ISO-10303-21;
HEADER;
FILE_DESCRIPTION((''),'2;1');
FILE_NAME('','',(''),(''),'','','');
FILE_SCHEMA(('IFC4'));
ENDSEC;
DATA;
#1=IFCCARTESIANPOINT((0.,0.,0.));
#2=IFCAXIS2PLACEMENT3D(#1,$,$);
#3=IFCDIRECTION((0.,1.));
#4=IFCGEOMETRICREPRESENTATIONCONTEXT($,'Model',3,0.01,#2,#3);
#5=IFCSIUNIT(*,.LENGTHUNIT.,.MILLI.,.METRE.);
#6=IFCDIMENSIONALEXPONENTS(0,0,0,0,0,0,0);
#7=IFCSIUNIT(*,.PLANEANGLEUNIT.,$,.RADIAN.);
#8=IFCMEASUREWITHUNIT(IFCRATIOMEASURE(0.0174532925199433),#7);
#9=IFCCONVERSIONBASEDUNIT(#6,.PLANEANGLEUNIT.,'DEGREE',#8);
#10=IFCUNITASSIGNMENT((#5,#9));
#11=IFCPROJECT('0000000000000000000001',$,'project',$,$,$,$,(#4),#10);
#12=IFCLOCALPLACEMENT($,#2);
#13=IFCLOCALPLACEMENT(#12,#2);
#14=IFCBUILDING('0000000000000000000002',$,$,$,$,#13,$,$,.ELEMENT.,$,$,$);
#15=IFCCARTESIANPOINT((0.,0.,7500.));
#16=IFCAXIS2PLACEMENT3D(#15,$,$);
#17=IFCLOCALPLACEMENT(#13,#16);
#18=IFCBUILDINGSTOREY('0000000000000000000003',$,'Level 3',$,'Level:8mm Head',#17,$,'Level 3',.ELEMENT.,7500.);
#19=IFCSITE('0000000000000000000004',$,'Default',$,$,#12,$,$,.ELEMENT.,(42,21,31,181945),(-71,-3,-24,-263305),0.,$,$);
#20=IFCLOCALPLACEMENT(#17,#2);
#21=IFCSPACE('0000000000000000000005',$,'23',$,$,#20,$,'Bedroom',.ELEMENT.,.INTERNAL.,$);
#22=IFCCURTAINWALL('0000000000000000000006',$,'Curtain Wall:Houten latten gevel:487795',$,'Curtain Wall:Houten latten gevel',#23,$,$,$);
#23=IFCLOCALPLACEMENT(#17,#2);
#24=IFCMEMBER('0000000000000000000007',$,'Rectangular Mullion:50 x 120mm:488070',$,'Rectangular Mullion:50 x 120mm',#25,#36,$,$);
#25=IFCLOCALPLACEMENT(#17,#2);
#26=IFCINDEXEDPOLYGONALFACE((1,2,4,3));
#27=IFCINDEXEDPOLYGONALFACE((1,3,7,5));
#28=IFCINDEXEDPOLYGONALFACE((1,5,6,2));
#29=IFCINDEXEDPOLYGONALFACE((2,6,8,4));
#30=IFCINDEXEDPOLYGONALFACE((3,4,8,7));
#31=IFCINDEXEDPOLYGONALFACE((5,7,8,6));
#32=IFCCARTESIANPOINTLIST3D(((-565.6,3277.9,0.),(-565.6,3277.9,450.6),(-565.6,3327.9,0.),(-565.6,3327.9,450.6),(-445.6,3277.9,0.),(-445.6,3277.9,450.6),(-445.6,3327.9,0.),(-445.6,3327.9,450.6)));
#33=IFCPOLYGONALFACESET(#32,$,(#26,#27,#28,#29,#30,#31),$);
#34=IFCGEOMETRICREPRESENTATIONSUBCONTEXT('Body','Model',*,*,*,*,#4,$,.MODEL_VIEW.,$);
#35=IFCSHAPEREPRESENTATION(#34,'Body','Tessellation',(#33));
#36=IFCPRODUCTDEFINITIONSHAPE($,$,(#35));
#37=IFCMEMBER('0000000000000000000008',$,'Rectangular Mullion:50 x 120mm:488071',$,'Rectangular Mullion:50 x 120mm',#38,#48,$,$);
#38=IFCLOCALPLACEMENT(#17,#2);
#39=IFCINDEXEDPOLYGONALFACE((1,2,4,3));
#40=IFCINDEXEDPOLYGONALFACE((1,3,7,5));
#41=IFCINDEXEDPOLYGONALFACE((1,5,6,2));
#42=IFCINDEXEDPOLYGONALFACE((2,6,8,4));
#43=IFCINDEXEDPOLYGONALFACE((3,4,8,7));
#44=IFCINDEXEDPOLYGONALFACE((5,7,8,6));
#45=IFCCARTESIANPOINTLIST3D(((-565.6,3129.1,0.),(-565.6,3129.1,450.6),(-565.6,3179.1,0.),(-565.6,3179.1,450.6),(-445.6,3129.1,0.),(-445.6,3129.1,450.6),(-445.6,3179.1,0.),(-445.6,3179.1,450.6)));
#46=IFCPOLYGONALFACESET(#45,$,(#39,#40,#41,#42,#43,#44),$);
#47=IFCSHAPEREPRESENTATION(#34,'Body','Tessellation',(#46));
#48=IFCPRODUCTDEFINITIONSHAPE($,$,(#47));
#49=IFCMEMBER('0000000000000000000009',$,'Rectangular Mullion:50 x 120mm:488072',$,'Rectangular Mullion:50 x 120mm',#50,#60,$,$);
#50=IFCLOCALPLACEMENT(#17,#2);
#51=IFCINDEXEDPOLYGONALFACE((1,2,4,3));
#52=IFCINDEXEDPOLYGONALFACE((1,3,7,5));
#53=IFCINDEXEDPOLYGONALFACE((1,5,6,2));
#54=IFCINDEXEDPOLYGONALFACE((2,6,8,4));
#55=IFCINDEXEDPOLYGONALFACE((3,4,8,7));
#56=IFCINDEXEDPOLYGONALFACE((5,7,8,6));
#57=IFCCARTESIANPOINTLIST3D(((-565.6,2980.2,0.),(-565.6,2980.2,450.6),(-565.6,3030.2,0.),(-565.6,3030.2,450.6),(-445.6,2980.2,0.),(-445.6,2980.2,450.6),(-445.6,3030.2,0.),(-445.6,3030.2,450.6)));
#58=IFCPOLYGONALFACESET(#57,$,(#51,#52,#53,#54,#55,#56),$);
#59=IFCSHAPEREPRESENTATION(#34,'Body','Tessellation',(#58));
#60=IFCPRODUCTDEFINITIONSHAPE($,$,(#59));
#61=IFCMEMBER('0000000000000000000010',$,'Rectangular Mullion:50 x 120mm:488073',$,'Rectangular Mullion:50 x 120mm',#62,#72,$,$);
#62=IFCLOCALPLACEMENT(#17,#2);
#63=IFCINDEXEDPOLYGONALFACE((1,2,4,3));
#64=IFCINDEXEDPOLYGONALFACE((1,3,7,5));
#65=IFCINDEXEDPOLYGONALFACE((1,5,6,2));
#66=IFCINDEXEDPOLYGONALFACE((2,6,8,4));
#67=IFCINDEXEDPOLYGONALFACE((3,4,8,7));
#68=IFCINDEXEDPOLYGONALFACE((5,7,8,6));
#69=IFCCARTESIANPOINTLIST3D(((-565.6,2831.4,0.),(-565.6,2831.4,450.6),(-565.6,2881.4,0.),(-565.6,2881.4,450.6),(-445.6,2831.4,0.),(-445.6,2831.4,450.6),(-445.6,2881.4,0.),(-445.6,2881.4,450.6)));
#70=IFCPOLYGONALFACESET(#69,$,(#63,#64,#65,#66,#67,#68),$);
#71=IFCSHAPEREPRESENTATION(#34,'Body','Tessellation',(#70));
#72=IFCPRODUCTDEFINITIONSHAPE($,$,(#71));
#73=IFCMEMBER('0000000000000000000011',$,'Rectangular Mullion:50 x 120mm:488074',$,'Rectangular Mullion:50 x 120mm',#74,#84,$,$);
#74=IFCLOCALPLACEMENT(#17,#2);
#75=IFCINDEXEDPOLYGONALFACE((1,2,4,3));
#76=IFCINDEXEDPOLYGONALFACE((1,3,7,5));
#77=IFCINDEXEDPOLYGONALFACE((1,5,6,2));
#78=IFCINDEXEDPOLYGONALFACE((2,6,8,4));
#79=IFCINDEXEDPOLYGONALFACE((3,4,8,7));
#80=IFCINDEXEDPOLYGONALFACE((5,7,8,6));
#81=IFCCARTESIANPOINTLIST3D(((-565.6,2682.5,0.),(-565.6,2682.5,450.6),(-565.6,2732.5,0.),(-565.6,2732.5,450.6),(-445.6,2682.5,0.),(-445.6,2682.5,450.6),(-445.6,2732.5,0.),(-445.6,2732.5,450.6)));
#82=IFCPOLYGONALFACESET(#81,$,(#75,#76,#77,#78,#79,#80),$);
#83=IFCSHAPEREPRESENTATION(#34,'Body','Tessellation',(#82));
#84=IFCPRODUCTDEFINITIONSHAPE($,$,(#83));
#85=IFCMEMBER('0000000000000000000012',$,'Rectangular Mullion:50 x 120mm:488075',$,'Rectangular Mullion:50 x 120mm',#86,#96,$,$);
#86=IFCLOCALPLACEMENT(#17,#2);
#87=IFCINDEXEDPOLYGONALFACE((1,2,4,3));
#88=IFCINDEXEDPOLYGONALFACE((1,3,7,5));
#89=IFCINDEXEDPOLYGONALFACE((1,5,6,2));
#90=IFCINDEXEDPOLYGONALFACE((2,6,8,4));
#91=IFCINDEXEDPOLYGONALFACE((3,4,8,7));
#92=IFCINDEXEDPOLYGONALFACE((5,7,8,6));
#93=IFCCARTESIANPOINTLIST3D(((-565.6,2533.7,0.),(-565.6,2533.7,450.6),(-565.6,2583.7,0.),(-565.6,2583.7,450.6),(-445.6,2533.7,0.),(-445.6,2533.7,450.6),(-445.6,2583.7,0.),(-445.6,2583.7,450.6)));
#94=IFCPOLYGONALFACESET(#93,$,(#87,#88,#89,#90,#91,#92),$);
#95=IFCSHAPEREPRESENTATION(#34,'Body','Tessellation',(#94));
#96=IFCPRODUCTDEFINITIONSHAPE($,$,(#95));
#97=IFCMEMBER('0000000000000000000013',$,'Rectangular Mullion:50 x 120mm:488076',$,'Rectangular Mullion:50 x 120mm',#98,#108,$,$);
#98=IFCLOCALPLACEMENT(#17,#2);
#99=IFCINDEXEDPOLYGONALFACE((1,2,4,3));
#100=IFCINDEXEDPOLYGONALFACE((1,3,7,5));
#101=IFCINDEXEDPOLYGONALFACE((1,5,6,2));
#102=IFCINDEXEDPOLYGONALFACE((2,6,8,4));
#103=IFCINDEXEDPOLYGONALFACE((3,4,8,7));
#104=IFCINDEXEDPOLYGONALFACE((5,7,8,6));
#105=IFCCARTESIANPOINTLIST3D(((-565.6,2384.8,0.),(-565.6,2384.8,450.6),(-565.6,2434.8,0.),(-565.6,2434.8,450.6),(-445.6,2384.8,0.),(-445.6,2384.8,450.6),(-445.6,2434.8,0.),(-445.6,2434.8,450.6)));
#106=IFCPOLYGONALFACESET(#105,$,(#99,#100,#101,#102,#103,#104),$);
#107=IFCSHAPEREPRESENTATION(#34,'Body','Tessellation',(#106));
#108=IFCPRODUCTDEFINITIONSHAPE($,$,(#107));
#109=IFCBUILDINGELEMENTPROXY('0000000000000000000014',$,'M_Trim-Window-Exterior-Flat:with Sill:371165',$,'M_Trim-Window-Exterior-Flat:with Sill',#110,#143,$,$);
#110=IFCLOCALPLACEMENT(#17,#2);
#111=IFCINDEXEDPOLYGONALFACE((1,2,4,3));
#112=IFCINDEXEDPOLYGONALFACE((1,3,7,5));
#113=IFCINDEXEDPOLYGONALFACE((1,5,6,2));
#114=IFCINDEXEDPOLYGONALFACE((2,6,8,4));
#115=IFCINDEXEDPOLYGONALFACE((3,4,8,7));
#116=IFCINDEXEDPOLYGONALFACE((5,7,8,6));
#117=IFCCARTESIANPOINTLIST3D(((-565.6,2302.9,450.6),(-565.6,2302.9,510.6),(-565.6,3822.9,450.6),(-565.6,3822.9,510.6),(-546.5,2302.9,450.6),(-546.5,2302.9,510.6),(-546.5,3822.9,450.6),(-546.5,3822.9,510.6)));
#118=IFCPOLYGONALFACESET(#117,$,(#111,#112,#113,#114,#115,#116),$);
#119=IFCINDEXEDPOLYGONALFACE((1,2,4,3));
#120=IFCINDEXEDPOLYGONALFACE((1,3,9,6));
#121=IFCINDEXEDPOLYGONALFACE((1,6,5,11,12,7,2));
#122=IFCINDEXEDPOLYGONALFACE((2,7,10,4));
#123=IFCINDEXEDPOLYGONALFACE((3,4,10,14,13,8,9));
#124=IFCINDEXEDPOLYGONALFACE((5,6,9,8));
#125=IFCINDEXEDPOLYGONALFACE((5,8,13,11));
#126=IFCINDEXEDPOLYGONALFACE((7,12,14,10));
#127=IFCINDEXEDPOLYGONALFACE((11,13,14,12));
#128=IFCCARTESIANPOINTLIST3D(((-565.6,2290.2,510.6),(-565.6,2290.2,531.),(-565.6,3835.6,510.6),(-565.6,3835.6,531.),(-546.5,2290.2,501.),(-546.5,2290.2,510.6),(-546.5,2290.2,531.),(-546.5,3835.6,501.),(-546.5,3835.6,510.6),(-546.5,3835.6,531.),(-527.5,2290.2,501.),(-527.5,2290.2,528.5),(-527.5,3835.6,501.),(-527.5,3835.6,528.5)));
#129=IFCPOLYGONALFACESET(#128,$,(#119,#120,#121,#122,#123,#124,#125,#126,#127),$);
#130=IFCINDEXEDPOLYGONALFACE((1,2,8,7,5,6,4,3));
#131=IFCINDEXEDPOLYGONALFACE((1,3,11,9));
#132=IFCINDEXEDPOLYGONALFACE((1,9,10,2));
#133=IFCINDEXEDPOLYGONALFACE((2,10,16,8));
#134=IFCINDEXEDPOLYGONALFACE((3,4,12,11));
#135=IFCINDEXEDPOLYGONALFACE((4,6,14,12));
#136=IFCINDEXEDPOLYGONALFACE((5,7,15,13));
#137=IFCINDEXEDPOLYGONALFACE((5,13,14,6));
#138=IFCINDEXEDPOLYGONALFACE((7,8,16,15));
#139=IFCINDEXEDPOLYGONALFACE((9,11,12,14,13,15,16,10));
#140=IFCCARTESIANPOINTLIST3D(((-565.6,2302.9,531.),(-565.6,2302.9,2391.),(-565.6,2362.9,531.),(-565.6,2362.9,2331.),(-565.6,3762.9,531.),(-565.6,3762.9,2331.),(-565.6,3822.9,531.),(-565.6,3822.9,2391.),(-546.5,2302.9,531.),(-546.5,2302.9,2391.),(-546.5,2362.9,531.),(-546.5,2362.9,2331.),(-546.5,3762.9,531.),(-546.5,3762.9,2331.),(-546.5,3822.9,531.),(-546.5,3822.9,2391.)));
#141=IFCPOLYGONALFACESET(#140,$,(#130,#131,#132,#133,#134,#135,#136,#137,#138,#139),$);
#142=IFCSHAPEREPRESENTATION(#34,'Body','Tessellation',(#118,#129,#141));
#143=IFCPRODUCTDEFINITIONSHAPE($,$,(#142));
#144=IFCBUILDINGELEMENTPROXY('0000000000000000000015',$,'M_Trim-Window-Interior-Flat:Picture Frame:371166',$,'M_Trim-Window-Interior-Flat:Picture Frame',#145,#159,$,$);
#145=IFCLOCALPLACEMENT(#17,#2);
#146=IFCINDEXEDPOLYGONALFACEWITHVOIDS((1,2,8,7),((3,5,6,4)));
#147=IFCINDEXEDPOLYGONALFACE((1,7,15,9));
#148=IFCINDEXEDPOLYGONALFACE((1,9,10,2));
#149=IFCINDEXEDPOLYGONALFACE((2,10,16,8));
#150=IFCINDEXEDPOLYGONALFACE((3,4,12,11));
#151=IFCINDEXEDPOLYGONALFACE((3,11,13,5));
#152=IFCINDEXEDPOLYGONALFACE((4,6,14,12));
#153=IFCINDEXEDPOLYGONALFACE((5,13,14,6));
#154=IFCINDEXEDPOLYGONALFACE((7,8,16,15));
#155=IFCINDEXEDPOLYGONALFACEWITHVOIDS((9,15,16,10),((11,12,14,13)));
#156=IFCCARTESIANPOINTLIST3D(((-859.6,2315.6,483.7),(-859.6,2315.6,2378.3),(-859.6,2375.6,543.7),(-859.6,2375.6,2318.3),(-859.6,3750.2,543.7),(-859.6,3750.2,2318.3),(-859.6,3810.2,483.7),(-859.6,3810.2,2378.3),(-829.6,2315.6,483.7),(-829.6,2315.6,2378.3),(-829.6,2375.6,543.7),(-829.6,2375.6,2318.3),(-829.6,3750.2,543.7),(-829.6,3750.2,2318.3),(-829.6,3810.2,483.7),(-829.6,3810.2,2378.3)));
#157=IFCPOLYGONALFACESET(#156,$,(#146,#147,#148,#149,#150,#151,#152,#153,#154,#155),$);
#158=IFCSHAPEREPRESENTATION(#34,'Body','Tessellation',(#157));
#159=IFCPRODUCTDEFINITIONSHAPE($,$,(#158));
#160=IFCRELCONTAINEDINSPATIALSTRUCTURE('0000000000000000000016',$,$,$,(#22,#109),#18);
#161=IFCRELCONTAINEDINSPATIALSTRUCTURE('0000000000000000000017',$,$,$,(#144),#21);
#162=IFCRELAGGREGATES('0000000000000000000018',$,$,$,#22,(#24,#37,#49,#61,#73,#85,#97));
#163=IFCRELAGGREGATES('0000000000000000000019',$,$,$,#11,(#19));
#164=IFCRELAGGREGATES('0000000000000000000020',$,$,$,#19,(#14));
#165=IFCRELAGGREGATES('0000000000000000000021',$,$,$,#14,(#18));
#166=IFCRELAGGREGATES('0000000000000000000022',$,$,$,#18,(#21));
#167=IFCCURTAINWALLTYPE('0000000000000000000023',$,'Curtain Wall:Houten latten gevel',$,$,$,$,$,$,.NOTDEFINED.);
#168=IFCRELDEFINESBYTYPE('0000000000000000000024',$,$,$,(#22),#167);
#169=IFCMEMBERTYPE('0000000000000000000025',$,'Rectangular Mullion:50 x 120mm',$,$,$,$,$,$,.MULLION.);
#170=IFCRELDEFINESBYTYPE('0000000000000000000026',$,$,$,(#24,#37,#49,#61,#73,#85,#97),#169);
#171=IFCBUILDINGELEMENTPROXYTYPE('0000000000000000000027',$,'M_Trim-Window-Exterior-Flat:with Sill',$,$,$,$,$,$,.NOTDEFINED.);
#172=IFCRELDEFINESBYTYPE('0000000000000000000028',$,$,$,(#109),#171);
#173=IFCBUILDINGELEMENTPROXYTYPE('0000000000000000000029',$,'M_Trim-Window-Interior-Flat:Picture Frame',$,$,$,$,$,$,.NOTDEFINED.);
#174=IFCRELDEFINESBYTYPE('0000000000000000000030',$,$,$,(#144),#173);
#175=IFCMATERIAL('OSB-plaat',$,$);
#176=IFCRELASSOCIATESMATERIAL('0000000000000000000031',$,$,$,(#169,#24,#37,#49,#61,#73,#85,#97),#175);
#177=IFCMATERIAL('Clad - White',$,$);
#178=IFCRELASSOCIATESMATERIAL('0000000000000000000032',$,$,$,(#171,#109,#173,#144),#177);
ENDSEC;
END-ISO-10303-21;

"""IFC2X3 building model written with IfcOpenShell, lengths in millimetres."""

from ifc_helpers import new_model, entity, si_unit, converted_unit, direction, frame, frame_2d, origin, origin_2d_with_axis, place, context, subcontext, project, spatial, polyline, rectangle, outline, extrude, source, transform, mapped, material, type_object, type_shapes, element, aggregate, save


model = new_model("IFC2X3")

# Units and contexts
model_context = context("Model", 3, precision=0.01, world=origin(), true_north=direction((0.0, 1.0)))
body_context = subcontext(model_context, "Body", "Model", "MODEL_VIEW")
ifc_project = project(units=[si_unit("LENGTHUNIT", "METRE", prefix="MILLI"), converted_unit("PLANEANGLEUNIT", "DEGREE", entity("IfcRatioMeasure", 0.0174532925199433), si_unit("PLANEANGLEUNIT", "RADIAN"), dimensions=[0, 0, 0, 0, 0, 0, 0])], contexts=[model_context])

# Site, building, storey
site_placement = place(None, frame((0.0, 0.0, 0.0)))
site = spatial("IfcSite", under=ifc_project, at=site_placement, Name="Default", CompositionType="ELEMENT", RefLatitude=(42, 21, 31, 181945), RefLongitude=(-71, -3, -24, -263305), RefElevation=0.0)
building_placement = place(site_placement, origin())
building = spatial("IfcBuilding", under=site, at=building_placement, CompositionType="ELEMENT")
storey_placement = place(building_placement, frame((0.0, 0.0, 7500.0)))
storey = spatial("IfcBuildingStorey", under=building, at=storey_placement, Name="Level 3", ObjectType="Level:8mm Head", LongName="Level 3", CompositionType="ELEMENT", Elevation=7500.0)

# Curtain wall, members
curtain_wall_type = type_object("IfcCurtainWallType", Name="Curtain Wall:Houten latten gevel", PredefinedType="NOTDEFINED")
curtain_wall_placement = place(storey_placement, frame((0.0, 0.0, -7500.0)))
curtain_wall = element("IfcCurtainWall", 1, at=curtain_wall_placement, inside=storey, type_object=curtain_wall_type, Name="Curtain Wall:Houten latten gevel:487795", ObjectType="Curtain Wall:Houten latten gevel")
ifc_material_1 = material(Name="OSB-plaat")
member_type_1 = type_object("IfcMemberType", Name="Rectangular Mullion:50 x 120mm", PredefinedType="MULLION", material=ifc_material_1)
shared_shape_1 = source(origin(), body_context, "Body", "SweptSolid", [
    extrude(rectangle(XDim=120.0, YDim=50.0, at=origin_2d_with_axis()), frame((0.0, 0.0, -450.6), z_axis=(0.0, 0.0, 1.0), x_axis=(0.0, -1.0, 0.0)), (0.0, 0.0, 1.0), 450.6),
])
type_shapes(member_type_1, [shared_shape_1])
member_1_placement = place(storey_placement, frame((-505.6, 3302.9, 0.0), z_axis=(0.0, 0.0, -1.0), x_axis=(0.0, -1.0, 0.0)))
member_1 = element("IfcMember", 2, at=member_1_placement, type_object=member_type_1, material=ifc_material_1, Name="Rectangular Mullion:50 x 120mm:488070", ObjectType="Rectangular Mullion:50 x 120mm", context=body_context, shape_type="MappedRepresentation", body=[
    mapped(shared_shape_1, transform((0.0, 0.0, 0.0), scale=1.0)),
])
member_2_placement = place(storey_placement, frame((-505.6, 3154.1, 0.0), z_axis=(0.0, 0.0, -1.0), x_axis=(0.0, -1.0, 0.0)))
member_2 = element("IfcMember", 3, at=member_2_placement, type_object=member_type_1, material=ifc_material_1, Name="Rectangular Mullion:50 x 120mm:488071", ObjectType="Rectangular Mullion:50 x 120mm", context=body_context, shape_type="MappedRepresentation", body=[
    mapped(shared_shape_1, transform((0.0, 0.0, 0.0), scale=1.0)),
])
member_3_placement = place(storey_placement, frame((-505.6, 3005.2, 0.0), z_axis=(0.0, 0.0, -1.0), x_axis=(0.0, -1.0, 0.0)))
member_3 = element("IfcMember", 4, at=member_3_placement, type_object=member_type_1, material=ifc_material_1, Name="Rectangular Mullion:50 x 120mm:488072", ObjectType="Rectangular Mullion:50 x 120mm", context=body_context, shape_type="MappedRepresentation", body=[
    mapped(shared_shape_1, transform((0.0, 0.0, 0.0), scale=1.0)),
])
member_4_placement = place(storey_placement, frame((-505.6, 2856.4, 0.0), z_axis=(0.0, 0.0, -1.0), x_axis=(0.0, -1.0, 0.0)))
member_4 = element("IfcMember", 5, at=member_4_placement, type_object=member_type_1, material=ifc_material_1, Name="Rectangular Mullion:50 x 120mm:488073", ObjectType="Rectangular Mullion:50 x 120mm", context=body_context, shape_type="MappedRepresentation", body=[
    mapped(shared_shape_1, transform((0.0, 0.0, 0.0), scale=1.0)),
])
member_5_placement = place(storey_placement, frame((-505.6, 2707.5, 0.0), z_axis=(0.0, 0.0, -1.0), x_axis=(0.0, -1.0, 0.0)))
member_5 = element("IfcMember", 6, at=member_5_placement, type_object=member_type_1, material=ifc_material_1, Name="Rectangular Mullion:50 x 120mm:488074", ObjectType="Rectangular Mullion:50 x 120mm", context=body_context, shape_type="MappedRepresentation", body=[
    mapped(shared_shape_1, transform((0.0, 0.0, 0.0), scale=1.0)),
])
member_6_placement = place(storey_placement, frame((-505.6, 2558.7, 0.0), z_axis=(0.0, 0.0, -1.0), x_axis=(0.0, -1.0, 0.0)))
member_6 = element("IfcMember", 7, at=member_6_placement, type_object=member_type_1, material=ifc_material_1, Name="Rectangular Mullion:50 x 120mm:488075", ObjectType="Rectangular Mullion:50 x 120mm", context=body_context, shape_type="MappedRepresentation", body=[
    mapped(shared_shape_1, transform((0.0, 0.0, 0.0), scale=1.0)),
])
member_7_placement = place(storey_placement, frame((-505.6, 2409.8, 0.0), z_axis=(0.0, 0.0, -1.0), x_axis=(0.0, -1.0, 0.0)))
member_7 = element("IfcMember", 8, at=member_7_placement, type_object=member_type_1, material=ifc_material_1, Name="Rectangular Mullion:50 x 120mm:488076", ObjectType="Rectangular Mullion:50 x 120mm", context=body_context, shape_type="MappedRepresentation", body=[
    mapped(shared_shape_1, transform((0.0, 0.0, 0.0), scale=1.0)),
])
aggregate(curtain_wall, [member_1, member_2, member_3, member_4, member_5, member_6, member_7])

# Building element proxy
ifc_material_2 = material(Name="Clad - White")
building_element_proxy_type_1 = type_object("IfcBuildingElementProxyType", Name="M_Trim-Window-Exterior-Flat:with Sill", PredefinedType="NOTDEFINED", material=ifc_material_2)
shared_shape_2 = source(origin(), body_context, "Body", "SweptSolid", [
    extrude(rectangle(XDim=1520.0, YDim=60.0, at=frame_2d((0.0, 0.0), x_axis=(1.0, 0.0))), frame((0.0, -1850.4, 0.0), z_axis=(0.0, 0.0, 1.0), x_axis=(-1.0, 0.0, 0.0)), (0.0, 0.0, 1.0), 19.1),
    extrude(outline(polyline([(-19.0, -15.2), (0.0, -15.2), (0.0, -5.7), (19.0, -5.7), (19.0, 14.8), (0.0, 14.8), (-19.0, 12.3), (-19.0, -15.2)])), frame((-772.7, -1814.8, 19.0), z_axis=(1.0, 0.0, 0.0), x_axis=(0.0, 0.0, -1.0)), (0.0, 0.0, 1.0), 1545.4),
    extrude(outline(polyline([(-945.0, -760.0), (915.0, -760.0), (915.0, -700.0), (-885.0, -700.0), (-885.0, 700.0), (915.0, 700.0), (915.0, 760.0), (-945.0, 760.0), (-945.0, -760.0)])), frame((0.0, -885.0, 0.0), z_axis=(0.0, 0.0, 1.0), x_axis=(0.0, -1.0, 0.0)), (0.0, 0.0, 1.0), 19.1),
])
type_shapes(building_element_proxy_type_1, [shared_shape_2])
proxy_1_placement = place(storey_placement, frame((-565.6, 3062.9, 2331.0), z_axis=(1.0, 0.0, 0.0), x_axis=(0.0, 1.0, 0.0)))
element("IfcBuildingElementProxy", 9, at=proxy_1_placement, inside=storey, type_object=building_element_proxy_type_1, material=ifc_material_2, Name="M_Trim-Window-Exterior-Flat:with Sill:371165", ObjectType="M_Trim-Window-Exterior-Flat:with Sill", context=body_context, shape_type="MappedRepresentation", body=[
    mapped(shared_shape_2, transform((0.0, 0.0, 0.0), scale=1.0)),
])

# Shared definitions
space_placement = place(storey_placement, origin())
space = spatial("IfcSpace", under=storey, at=space_placement, Name="23", LongName="Bedroom", CompositionType="ELEMENT", InteriorOrExteriorSpace="INTERNAL")

# Building element proxy
building_element_proxy_type_2 = type_object("IfcBuildingElementProxyType", Name="M_Trim-Window-Interior-Flat:Picture Frame", PredefinedType="NOTDEFINED", material=ifc_material_2)
shared_shape_3 = source(origin(), body_context, "Body", "SweptSolid", [
    extrude(outline(polyline([(-747.3, -947.3), (747.3, -947.3), (747.3, 947.3), (-747.3, 947.3), (-747.3, -947.3)]), holes=[polyline([(-687.3, -887.3), (-687.3, 887.3), (687.3, 887.3), (687.3, -887.3), (-687.3, -887.3)])]), frame((0.0, -900.0, 0.0), z_axis=(0.0, 0.0, 1.0), x_axis=(-1.0, 0.0, 0.0)), (0.0, 0.0, 1.0), 30.0),
])
type_shapes(building_element_proxy_type_2, [shared_shape_3])
proxy_2_placement = place(space_placement, frame((-829.6, 3062.9, 2331.0), z_axis=(-1.0, 0.0, 0.0), x_axis=(0.0, -1.0, 0.0)))
element("IfcBuildingElementProxy", 10, at=proxy_2_placement, inside=space, type_object=building_element_proxy_type_2, material=ifc_material_2, Name="M_Trim-Window-Interior-Flat:Picture Frame:371166", ObjectType="M_Trim-Window-Interior-Flat:Picture Frame", context=body_context, shape_type="MappedRepresentation", body=[
    mapped(shared_shape_3, transform((0.0, 0.0, 0.0), scale=1.0)),
])

save(model, "model.ifc")
